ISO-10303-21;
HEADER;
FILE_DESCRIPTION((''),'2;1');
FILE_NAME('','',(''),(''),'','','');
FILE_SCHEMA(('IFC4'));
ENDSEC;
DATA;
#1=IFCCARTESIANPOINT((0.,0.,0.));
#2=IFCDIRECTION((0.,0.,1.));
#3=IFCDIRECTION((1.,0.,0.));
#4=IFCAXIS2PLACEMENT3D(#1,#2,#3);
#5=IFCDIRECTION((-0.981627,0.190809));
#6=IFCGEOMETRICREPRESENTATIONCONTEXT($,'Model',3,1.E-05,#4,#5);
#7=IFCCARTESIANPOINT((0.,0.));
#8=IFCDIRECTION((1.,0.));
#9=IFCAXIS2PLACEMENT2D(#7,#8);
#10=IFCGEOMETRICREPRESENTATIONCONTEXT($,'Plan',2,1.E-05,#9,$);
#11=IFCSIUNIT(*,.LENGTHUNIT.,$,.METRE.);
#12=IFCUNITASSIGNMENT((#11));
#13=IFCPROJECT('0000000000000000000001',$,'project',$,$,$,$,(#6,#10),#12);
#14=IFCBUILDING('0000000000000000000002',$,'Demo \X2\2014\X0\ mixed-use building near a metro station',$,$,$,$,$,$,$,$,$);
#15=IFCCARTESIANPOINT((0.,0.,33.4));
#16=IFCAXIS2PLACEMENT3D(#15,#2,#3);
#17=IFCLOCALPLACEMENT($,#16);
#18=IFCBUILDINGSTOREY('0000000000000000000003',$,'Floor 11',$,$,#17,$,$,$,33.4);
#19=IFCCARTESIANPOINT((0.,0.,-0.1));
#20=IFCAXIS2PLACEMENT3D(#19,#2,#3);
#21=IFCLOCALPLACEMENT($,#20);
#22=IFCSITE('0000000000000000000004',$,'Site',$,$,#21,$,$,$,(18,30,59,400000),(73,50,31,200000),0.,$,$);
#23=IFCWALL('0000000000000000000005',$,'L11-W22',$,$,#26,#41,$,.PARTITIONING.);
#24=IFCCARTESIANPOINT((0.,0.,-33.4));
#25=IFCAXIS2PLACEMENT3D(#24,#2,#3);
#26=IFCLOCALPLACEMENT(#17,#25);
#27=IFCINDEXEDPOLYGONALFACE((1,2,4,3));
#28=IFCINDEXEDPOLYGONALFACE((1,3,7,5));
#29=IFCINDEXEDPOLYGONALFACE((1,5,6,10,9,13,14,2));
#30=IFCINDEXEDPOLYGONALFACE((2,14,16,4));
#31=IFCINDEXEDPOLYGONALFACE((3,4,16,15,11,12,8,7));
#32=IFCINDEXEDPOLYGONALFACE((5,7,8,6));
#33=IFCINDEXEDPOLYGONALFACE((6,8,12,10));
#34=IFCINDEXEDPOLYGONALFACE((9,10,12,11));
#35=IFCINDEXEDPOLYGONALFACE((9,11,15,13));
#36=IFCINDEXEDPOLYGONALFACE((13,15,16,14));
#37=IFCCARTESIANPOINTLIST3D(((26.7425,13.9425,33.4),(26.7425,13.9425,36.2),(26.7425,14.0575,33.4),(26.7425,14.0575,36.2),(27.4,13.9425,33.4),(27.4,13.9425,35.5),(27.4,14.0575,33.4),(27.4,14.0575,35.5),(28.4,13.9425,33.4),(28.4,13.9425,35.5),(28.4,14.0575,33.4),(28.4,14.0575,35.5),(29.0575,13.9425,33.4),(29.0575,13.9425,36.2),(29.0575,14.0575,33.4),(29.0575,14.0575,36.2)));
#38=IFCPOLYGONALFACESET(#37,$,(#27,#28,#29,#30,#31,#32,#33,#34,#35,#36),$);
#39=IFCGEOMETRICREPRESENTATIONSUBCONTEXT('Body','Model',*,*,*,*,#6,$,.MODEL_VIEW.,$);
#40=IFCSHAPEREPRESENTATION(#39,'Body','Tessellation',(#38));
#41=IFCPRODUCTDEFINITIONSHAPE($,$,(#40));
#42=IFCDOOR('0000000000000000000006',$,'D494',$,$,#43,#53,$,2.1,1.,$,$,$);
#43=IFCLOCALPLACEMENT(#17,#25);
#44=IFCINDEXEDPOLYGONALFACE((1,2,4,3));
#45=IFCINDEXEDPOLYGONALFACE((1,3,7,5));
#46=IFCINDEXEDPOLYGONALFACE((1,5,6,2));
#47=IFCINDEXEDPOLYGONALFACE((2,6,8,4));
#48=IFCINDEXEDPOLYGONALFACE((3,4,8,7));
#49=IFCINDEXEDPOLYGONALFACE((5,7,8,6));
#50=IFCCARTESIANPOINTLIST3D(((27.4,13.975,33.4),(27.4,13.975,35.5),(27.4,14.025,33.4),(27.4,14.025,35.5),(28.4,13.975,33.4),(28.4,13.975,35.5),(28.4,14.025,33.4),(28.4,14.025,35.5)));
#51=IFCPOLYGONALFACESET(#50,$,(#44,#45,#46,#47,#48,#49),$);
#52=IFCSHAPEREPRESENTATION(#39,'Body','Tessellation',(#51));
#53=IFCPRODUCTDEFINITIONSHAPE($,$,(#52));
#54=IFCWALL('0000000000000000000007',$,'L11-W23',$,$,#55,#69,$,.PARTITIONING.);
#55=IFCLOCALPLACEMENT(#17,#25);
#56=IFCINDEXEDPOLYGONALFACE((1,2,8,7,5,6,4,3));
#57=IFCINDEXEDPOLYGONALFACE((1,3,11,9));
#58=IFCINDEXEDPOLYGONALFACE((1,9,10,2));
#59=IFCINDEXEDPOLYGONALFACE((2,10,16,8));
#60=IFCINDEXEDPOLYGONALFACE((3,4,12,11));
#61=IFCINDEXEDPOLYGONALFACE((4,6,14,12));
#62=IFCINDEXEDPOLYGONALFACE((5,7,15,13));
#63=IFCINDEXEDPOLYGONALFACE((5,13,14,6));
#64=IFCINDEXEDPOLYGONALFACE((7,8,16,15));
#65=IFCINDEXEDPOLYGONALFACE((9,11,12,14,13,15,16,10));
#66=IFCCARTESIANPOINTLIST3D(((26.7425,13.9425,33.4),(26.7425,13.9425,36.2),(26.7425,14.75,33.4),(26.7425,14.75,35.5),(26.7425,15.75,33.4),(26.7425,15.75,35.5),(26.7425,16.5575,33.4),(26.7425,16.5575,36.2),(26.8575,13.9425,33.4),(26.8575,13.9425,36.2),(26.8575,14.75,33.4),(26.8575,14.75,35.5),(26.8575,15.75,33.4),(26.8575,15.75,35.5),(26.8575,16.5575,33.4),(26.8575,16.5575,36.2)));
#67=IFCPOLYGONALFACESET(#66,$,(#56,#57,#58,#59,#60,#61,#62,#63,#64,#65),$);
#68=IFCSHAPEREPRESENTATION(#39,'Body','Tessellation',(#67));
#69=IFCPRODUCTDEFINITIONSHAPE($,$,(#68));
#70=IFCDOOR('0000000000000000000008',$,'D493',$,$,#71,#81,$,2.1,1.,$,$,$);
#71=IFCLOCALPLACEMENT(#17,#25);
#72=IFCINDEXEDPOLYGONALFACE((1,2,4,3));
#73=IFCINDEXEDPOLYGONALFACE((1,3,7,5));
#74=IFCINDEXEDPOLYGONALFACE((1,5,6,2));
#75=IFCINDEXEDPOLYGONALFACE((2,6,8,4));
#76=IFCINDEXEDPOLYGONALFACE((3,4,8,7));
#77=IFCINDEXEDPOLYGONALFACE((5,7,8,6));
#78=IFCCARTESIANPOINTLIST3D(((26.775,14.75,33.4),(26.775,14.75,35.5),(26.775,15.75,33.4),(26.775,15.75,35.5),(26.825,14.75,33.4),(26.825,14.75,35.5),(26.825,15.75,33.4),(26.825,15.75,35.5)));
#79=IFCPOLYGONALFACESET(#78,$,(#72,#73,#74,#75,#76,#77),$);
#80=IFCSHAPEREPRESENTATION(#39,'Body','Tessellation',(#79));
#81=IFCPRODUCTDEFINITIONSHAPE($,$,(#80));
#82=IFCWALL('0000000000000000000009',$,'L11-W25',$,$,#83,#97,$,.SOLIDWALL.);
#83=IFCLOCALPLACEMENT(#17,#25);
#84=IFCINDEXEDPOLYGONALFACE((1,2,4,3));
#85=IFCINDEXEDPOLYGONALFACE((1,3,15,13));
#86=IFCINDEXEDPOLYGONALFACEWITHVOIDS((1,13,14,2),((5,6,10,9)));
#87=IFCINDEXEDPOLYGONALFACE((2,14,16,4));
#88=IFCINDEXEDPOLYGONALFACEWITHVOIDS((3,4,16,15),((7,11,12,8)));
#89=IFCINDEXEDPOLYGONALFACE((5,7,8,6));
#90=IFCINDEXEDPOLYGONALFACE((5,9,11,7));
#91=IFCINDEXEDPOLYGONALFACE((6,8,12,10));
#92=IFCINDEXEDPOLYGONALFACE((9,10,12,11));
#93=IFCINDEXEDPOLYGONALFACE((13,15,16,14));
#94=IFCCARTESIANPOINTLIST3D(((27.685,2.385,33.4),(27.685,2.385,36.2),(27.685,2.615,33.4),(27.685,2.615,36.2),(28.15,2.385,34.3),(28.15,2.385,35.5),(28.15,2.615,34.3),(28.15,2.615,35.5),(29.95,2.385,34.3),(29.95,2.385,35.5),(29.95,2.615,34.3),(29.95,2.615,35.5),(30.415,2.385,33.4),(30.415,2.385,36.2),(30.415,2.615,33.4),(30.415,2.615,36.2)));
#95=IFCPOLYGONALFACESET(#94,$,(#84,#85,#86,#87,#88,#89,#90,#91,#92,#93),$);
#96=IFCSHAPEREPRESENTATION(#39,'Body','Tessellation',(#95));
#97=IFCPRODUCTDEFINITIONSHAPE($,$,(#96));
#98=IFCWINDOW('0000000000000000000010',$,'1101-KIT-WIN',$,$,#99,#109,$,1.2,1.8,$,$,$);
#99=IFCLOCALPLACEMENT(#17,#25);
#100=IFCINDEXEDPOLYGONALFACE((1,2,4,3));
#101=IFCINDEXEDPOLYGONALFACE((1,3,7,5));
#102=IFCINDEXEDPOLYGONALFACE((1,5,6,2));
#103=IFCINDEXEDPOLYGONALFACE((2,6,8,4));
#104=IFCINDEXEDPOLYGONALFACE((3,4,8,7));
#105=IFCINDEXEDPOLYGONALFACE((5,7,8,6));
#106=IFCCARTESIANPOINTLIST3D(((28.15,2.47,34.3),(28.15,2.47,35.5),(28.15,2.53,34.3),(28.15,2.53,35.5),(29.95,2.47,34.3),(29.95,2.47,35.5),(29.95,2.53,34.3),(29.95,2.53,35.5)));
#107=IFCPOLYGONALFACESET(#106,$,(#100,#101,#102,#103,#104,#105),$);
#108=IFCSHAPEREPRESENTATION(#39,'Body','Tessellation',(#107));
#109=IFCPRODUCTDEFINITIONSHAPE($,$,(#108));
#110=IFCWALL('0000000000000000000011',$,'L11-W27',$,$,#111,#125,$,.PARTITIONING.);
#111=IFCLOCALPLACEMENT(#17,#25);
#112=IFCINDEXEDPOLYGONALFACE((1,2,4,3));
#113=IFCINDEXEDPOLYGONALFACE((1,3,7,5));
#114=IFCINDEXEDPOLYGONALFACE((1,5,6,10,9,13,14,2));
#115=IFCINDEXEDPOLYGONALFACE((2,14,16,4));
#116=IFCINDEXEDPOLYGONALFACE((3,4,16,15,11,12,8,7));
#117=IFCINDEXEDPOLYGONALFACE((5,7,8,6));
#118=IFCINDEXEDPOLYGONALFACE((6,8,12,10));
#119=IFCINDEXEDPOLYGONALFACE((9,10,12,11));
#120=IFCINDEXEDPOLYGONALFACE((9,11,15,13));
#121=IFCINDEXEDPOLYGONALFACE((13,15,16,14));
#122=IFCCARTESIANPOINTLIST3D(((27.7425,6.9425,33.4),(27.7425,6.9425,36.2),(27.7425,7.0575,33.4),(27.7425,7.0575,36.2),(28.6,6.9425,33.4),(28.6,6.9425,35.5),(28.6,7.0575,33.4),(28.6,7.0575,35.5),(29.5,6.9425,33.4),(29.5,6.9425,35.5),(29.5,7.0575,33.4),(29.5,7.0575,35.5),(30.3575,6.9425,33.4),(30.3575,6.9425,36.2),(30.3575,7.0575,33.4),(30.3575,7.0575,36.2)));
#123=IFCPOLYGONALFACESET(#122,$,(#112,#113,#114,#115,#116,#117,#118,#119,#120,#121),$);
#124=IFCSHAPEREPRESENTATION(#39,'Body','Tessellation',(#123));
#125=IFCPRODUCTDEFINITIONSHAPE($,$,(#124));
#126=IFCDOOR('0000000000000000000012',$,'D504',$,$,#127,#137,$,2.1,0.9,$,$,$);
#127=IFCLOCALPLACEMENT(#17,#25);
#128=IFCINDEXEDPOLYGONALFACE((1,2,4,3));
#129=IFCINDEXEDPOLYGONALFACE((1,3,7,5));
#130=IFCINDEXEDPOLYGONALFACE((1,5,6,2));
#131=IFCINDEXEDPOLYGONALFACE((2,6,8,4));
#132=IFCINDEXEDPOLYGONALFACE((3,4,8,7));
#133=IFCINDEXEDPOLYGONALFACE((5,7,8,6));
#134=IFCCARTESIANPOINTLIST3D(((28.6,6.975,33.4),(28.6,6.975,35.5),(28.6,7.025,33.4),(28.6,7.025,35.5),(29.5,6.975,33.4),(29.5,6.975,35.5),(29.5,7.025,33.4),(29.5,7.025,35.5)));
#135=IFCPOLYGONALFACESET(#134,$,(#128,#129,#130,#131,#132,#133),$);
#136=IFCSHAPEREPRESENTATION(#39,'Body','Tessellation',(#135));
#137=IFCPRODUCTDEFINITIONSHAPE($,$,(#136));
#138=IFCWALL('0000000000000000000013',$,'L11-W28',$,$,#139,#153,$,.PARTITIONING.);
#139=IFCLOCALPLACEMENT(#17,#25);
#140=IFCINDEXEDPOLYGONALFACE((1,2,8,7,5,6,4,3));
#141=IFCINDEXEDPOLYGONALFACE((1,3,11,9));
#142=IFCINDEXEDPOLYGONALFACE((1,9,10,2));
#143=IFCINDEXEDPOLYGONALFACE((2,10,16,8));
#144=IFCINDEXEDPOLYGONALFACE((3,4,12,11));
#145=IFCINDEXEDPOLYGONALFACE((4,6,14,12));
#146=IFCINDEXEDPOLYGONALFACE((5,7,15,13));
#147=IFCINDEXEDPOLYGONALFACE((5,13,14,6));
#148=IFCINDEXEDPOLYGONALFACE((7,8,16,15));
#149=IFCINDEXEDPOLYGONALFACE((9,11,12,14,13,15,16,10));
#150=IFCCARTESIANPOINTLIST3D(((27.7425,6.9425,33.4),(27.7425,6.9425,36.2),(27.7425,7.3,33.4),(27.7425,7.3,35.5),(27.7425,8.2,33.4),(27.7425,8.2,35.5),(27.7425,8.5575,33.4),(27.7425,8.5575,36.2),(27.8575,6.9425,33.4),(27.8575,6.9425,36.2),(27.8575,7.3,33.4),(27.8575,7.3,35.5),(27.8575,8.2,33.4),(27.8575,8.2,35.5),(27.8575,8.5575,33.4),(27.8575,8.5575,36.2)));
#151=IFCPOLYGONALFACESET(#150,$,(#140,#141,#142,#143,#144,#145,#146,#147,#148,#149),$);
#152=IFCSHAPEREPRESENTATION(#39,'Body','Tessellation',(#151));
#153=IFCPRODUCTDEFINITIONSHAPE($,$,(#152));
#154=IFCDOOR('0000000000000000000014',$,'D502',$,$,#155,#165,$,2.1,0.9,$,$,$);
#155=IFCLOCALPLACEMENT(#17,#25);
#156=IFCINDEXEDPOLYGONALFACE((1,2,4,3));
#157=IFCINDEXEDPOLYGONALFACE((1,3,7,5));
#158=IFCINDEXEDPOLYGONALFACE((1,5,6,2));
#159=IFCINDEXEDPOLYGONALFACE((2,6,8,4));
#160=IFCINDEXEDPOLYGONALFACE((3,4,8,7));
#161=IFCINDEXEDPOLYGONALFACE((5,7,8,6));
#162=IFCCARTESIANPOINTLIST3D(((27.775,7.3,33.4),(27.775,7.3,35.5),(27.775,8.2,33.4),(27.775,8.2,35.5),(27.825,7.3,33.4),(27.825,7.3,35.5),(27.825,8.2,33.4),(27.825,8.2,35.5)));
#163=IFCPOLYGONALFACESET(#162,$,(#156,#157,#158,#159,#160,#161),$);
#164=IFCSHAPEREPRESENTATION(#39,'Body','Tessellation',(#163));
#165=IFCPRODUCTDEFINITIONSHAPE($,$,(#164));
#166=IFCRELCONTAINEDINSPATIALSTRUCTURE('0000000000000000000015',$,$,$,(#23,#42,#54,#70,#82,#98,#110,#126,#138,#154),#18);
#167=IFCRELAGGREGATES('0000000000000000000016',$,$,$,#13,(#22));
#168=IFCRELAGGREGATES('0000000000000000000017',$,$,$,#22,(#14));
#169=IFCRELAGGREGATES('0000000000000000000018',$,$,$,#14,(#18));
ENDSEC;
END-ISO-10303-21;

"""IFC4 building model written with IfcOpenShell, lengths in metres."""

from ifc_helpers import new_model, si_unit, direction, frame, origin_with_axes, origin_2d_with_axis, place, context, subcontext, project, spatial, line, indexed_curve, outline, extrude, element, fill, save


model = new_model("IFC4")

# Units and contexts
model_context = context("Model", 3, precision=1e-05, world=origin_with_axes(), true_north=direction((-0.981627, 0.190809)))
plan_context = context("Plan", 2, precision=1e-05, world=origin_2d_with_axis())
body_context = subcontext(model_context, "Body", "Model", "MODEL_VIEW")
ifc_project = project(units=[si_unit("LENGTHUNIT", "METRE")], contexts=[model_context, plan_context])

# Site, building, storey
site_placement = place(None, frame((0.0, 0.0, -0.1), z_axis=(0.0, 0.0, 1.0), x_axis=(1.0, 0.0, 0.0)))
site = spatial("IfcSite", under=ifc_project, at=site_placement, Name="Site", RefLatitude=(18, 30, 59, 400000), RefLongitude=(73, 50, 31, 200000), RefElevation=0.0)
building = spatial("IfcBuilding", under=site, Name="Demo — mixed-use building near a metro station")
storey_placement = place(None, frame((0.0, 0.0, 33.4), z_axis=(0.0, 0.0, 1.0), x_axis=(1.0, 0.0, 0.0)))
storey = spatial("IfcBuildingStorey", under=building, at=storey_placement, Name="Floor 11", Elevation=33.4)

# Walls, openings, doors
wall_1_placement = place(storey_placement, frame((0.0, 0.0, -33.4), z_axis=(0.0, 0.0, 1.0), x_axis=(1.0, 0.0, 0.0)))
wall_1 = element("IfcWall", 1, at=wall_1_placement, inside=storey, Name="L11-W22", PredefinedType="PARTITIONING", context=body_context, shape_type="SweptSolid", body=[
    extrude(outline(indexed_curve([(29.0575, 13.9425), (26.7425, 13.9425), (26.7425, 14.0575), (29.0575, 14.0575)], segments=[line(1, 2, 3, 4, 1)])), frame((0.0, 0.0, 33.4), z_axis=(0.0, 0.0, 1.0), x_axis=(1.0, 0.0, 0.0)), (0.0, 0.0, 1.0), 2.8),
])
opening_1_placement = place(wall_1_placement, origin_with_axes())
opening_1 = element("IfcOpeningElement", 2, at=opening_1_placement, cuts=wall_1, context=body_context, shape_type="SweptSolid", body=[
    extrude(outline(indexed_curve([(28.4, 13.8925), (27.4, 13.8925), (27.4, 14.1075), (28.4, 14.1075)], segments=[line(1, 2, 3, 4, 1)])), frame((0.0, 0.0, 33.4), z_axis=(0.0, 0.0, 1.0), x_axis=(1.0, 0.0, 0.0)), (0.0, 0.0, 1.0), 2.1),
])
door_1_placement = place(storey_placement, frame((0.0, 0.0, -33.4), z_axis=(0.0, 0.0, 1.0), x_axis=(1.0, 0.0, 0.0)))
door_1 = element("IfcDoor", 3, at=door_1_placement, inside=storey, Name="D494", OverallHeight=2.1, OverallWidth=1.0, context=body_context, shape_type="SweptSolid", body=[
    extrude(outline(indexed_curve([(28.4, 13.975), (27.4, 13.975), (27.4, 14.025), (28.4, 14.025)], segments=[line(1, 2, 3, 4, 1)])), frame((0.0, 0.0, 33.4), z_axis=(0.0, 0.0, 1.0), x_axis=(1.0, 0.0, 0.0)), (0.0, 0.0, 1.0), 2.1),
])
fill(opening_1, door_1)
wall_2_placement = place(storey_placement, frame((0.0, 0.0, -33.4), z_axis=(0.0, 0.0, 1.0), x_axis=(1.0, 0.0, 0.0)))
wall_2 = element("IfcWall", 4, at=wall_2_placement, inside=storey, Name="L11-W23", PredefinedType="PARTITIONING", context=body_context, shape_type="SweptSolid", body=[
    extrude(outline(indexed_curve([(26.7425, 13.9425), (26.7425, 16.5575), (26.8575, 16.5575), (26.8575, 13.9425)], segments=[line(1, 2, 3, 4, 1)])), frame((0.0, 0.0, 33.4), z_axis=(0.0, 0.0, 1.0), x_axis=(1.0, 0.0, 0.0)), (0.0, 0.0, 1.0), 2.8),
])
opening_2_placement = place(wall_2_placement, origin_with_axes())
opening_2 = element("IfcOpeningElement", 5, at=opening_2_placement, cuts=wall_2, context=body_context, shape_type="SweptSolid", body=[
    extrude(outline(indexed_curve([(26.6925, 14.75), (26.6925, 15.75), (26.9075, 15.75), (26.9075, 14.75)], segments=[line(1, 2, 3, 4, 1)])), frame((0.0, 0.0, 33.4), z_axis=(0.0, 0.0, 1.0), x_axis=(1.0, 0.0, 0.0)), (0.0, 0.0, 1.0), 2.1),
])
door_2_placement = place(storey_placement, frame((0.0, 0.0, -33.4), z_axis=(0.0, 0.0, 1.0), x_axis=(1.0, 0.0, 0.0)))
door_2 = element("IfcDoor", 6, at=door_2_placement, inside=storey, Name="D493", OverallHeight=2.1, OverallWidth=1.0, context=body_context, shape_type="SweptSolid", body=[
    extrude(outline(indexed_curve([(26.775, 14.75), (26.775, 15.75), (26.825, 15.75), (26.825, 14.75)], segments=[line(1, 2, 3, 4, 1)])), frame((0.0, 0.0, 33.4), z_axis=(0.0, 0.0, 1.0), x_axis=(1.0, 0.0, 0.0)), (0.0, 0.0, 1.0), 2.1),
])
fill(opening_2, door_2)

# Wall, opening, window
wall_3_placement = place(storey_placement, frame((0.0, 0.0, -33.4), z_axis=(0.0, 0.0, 1.0), x_axis=(1.0, 0.0, 0.0)))
wall_3 = element("IfcWall", 7, at=wall_3_placement, inside=storey, Name="L11-W25", PredefinedType="SOLIDWALL", context=body_context, shape_type="SweptSolid", body=[
    extrude(outline(indexed_curve([(27.685, 2.615), (30.415, 2.615), (30.415, 2.385), (27.685, 2.385)], segments=[line(1, 2, 3, 4, 1)])), frame((0.0, 0.0, 33.4), z_axis=(0.0, 0.0, 1.0), x_axis=(1.0, 0.0, 0.0)), (0.0, 0.0, 1.0), 2.8),
])
opening_3_placement = place(wall_3_placement, origin_with_axes())
opening_3 = element("IfcOpeningElement", 8, at=opening_3_placement, cuts=wall_3, context=body_context, shape_type="SweptSolid", body=[
    extrude(outline(indexed_curve([(28.15, 2.665), (29.95, 2.665), (29.95, 2.335), (28.15, 2.335)], segments=[line(1, 2, 3, 4, 1)])), frame((0.0, 0.0, 34.3), z_axis=(0.0, 0.0, 1.0), x_axis=(1.0, 0.0, 0.0)), (0.0, 0.0, 1.0), 1.2),
])
window_placement = place(storey_placement, frame((0.0, 0.0, -33.4), z_axis=(0.0, 0.0, 1.0), x_axis=(1.0, 0.0, 0.0)))
window = element("IfcWindow", 9, at=window_placement, inside=storey, Name="1101-KIT-WIN", OverallHeight=1.2, OverallWidth=1.8, context=body_context, shape_type="SweptSolid", body=[
    extrude(outline(indexed_curve([(28.15, 2.53), (29.95, 2.53), (29.95, 2.47), (28.15, 2.47)], segments=[line(1, 2, 3, 4, 1)])), frame((0.0, 0.0, 34.3), z_axis=(0.0, 0.0, 1.0), x_axis=(1.0, 0.0, 0.0)), (0.0, 0.0, 1.0), 1.2),
])
fill(opening_3, window)

# Walls, openings, doors
wall_4_placement = place(storey_placement, frame((0.0, 0.0, -33.4), z_axis=(0.0, 0.0, 1.0), x_axis=(1.0, 0.0, 0.0)))
wall_4 = element("IfcWall", 10, at=wall_4_placement, inside=storey, Name="L11-W27", PredefinedType="PARTITIONING", context=body_context, shape_type="SweptSolid", body=[
    extrude(outline(indexed_curve([(30.3575, 6.9425), (27.7425, 6.9425), (27.7425, 7.0575), (30.3575, 7.0575)], segments=[line(1, 2, 3, 4, 1)])), frame((0.0, 0.0, 33.4), z_axis=(0.0, 0.0, 1.0), x_axis=(1.0, 0.0, 0.0)), (0.0, 0.0, 1.0), 2.8),
])
opening_4_placement = place(wall_4_placement, origin_with_axes())
opening_4 = element("IfcOpeningElement", 11, at=opening_4_placement, cuts=wall_4, context=body_context, shape_type="SweptSolid", body=[
    extrude(outline(indexed_curve([(29.5, 6.8925), (28.6, 6.8925), (28.6, 7.1075), (29.5, 7.1075)], segments=[line(1, 2, 3, 4, 1)])), frame((0.0, 0.0, 33.4), z_axis=(0.0, 0.0, 1.0), x_axis=(1.0, 0.0, 0.0)), (0.0, 0.0, 1.0), 2.1),
])
door_3_placement = place(storey_placement, frame((0.0, 0.0, -33.4), z_axis=(0.0, 0.0, 1.0), x_axis=(1.0, 0.0, 0.0)))
door_3 = element("IfcDoor", 12, at=door_3_placement, inside=storey, Name="D504", OverallHeight=2.1, OverallWidth=0.9, context=body_context, shape_type="SweptSolid", body=[
    extrude(outline(indexed_curve([(29.5, 6.975), (28.6, 6.975), (28.6, 7.025), (29.5, 7.025)], segments=[line(1, 2, 3, 4, 1)])), frame((0.0, 0.0, 33.4), z_axis=(0.0, 0.0, 1.0), x_axis=(1.0, 0.0, 0.0)), (0.0, 0.0, 1.0), 2.1),
])
fill(opening_4, door_3)
wall_5_placement = place(storey_placement, frame((0.0, 0.0, -33.4), z_axis=(0.0, 0.0, 1.0), x_axis=(1.0, 0.0, 0.0)))
wall_5 = element("IfcWall", 13, at=wall_5_placement, inside=storey, Name="L11-W28", PredefinedType="PARTITIONING", context=body_context, shape_type="SweptSolid", body=[
    extrude(outline(indexed_curve([(27.7425, 6.9425), (27.7425, 8.5575), (27.8575, 8.5575), (27.8575, 6.9425)], segments=[line(1, 2, 3, 4, 1)])), frame((0.0, 0.0, 33.4), z_axis=(0.0, 0.0, 1.0), x_axis=(1.0, 0.0, 0.0)), (0.0, 0.0, 1.0), 2.8),
])
opening_5_placement = place(wall_5_placement, origin_with_axes())
opening_5 = element("IfcOpeningElement", 14, at=opening_5_placement, cuts=wall_5, context=body_context, shape_type="SweptSolid", body=[
    extrude(outline(indexed_curve([(27.6925, 7.3), (27.6925, 8.2), (27.9075, 8.2), (27.9075, 7.3)], segments=[line(1, 2, 3, 4, 1)])), frame((0.0, 0.0, 33.4), z_axis=(0.0, 0.0, 1.0), x_axis=(1.0, 0.0, 0.0)), (0.0, 0.0, 1.0), 2.1),
])
door_4_placement = place(storey_placement, frame((0.0, 0.0, -33.4), z_axis=(0.0, 0.0, 1.0), x_axis=(1.0, 0.0, 0.0)))
door_4 = element("IfcDoor", 15, at=door_4_placement, inside=storey, Name="D502", OverallHeight=2.1, OverallWidth=0.9, context=body_context, shape_type="SweptSolid", body=[
    extrude(outline(indexed_curve([(27.775, 7.3), (27.775, 8.2), (27.825, 8.2), (27.825, 7.3)], segments=[line(1, 2, 3, 4, 1)])), frame((0.0, 0.0, 33.4), z_axis=(0.0, 0.0, 1.0), x_axis=(1.0, 0.0, 0.0)), (0.0, 0.0, 1.0), 2.1),
])
fill(opening_5, door_4)

save(model, "model.ifc")
